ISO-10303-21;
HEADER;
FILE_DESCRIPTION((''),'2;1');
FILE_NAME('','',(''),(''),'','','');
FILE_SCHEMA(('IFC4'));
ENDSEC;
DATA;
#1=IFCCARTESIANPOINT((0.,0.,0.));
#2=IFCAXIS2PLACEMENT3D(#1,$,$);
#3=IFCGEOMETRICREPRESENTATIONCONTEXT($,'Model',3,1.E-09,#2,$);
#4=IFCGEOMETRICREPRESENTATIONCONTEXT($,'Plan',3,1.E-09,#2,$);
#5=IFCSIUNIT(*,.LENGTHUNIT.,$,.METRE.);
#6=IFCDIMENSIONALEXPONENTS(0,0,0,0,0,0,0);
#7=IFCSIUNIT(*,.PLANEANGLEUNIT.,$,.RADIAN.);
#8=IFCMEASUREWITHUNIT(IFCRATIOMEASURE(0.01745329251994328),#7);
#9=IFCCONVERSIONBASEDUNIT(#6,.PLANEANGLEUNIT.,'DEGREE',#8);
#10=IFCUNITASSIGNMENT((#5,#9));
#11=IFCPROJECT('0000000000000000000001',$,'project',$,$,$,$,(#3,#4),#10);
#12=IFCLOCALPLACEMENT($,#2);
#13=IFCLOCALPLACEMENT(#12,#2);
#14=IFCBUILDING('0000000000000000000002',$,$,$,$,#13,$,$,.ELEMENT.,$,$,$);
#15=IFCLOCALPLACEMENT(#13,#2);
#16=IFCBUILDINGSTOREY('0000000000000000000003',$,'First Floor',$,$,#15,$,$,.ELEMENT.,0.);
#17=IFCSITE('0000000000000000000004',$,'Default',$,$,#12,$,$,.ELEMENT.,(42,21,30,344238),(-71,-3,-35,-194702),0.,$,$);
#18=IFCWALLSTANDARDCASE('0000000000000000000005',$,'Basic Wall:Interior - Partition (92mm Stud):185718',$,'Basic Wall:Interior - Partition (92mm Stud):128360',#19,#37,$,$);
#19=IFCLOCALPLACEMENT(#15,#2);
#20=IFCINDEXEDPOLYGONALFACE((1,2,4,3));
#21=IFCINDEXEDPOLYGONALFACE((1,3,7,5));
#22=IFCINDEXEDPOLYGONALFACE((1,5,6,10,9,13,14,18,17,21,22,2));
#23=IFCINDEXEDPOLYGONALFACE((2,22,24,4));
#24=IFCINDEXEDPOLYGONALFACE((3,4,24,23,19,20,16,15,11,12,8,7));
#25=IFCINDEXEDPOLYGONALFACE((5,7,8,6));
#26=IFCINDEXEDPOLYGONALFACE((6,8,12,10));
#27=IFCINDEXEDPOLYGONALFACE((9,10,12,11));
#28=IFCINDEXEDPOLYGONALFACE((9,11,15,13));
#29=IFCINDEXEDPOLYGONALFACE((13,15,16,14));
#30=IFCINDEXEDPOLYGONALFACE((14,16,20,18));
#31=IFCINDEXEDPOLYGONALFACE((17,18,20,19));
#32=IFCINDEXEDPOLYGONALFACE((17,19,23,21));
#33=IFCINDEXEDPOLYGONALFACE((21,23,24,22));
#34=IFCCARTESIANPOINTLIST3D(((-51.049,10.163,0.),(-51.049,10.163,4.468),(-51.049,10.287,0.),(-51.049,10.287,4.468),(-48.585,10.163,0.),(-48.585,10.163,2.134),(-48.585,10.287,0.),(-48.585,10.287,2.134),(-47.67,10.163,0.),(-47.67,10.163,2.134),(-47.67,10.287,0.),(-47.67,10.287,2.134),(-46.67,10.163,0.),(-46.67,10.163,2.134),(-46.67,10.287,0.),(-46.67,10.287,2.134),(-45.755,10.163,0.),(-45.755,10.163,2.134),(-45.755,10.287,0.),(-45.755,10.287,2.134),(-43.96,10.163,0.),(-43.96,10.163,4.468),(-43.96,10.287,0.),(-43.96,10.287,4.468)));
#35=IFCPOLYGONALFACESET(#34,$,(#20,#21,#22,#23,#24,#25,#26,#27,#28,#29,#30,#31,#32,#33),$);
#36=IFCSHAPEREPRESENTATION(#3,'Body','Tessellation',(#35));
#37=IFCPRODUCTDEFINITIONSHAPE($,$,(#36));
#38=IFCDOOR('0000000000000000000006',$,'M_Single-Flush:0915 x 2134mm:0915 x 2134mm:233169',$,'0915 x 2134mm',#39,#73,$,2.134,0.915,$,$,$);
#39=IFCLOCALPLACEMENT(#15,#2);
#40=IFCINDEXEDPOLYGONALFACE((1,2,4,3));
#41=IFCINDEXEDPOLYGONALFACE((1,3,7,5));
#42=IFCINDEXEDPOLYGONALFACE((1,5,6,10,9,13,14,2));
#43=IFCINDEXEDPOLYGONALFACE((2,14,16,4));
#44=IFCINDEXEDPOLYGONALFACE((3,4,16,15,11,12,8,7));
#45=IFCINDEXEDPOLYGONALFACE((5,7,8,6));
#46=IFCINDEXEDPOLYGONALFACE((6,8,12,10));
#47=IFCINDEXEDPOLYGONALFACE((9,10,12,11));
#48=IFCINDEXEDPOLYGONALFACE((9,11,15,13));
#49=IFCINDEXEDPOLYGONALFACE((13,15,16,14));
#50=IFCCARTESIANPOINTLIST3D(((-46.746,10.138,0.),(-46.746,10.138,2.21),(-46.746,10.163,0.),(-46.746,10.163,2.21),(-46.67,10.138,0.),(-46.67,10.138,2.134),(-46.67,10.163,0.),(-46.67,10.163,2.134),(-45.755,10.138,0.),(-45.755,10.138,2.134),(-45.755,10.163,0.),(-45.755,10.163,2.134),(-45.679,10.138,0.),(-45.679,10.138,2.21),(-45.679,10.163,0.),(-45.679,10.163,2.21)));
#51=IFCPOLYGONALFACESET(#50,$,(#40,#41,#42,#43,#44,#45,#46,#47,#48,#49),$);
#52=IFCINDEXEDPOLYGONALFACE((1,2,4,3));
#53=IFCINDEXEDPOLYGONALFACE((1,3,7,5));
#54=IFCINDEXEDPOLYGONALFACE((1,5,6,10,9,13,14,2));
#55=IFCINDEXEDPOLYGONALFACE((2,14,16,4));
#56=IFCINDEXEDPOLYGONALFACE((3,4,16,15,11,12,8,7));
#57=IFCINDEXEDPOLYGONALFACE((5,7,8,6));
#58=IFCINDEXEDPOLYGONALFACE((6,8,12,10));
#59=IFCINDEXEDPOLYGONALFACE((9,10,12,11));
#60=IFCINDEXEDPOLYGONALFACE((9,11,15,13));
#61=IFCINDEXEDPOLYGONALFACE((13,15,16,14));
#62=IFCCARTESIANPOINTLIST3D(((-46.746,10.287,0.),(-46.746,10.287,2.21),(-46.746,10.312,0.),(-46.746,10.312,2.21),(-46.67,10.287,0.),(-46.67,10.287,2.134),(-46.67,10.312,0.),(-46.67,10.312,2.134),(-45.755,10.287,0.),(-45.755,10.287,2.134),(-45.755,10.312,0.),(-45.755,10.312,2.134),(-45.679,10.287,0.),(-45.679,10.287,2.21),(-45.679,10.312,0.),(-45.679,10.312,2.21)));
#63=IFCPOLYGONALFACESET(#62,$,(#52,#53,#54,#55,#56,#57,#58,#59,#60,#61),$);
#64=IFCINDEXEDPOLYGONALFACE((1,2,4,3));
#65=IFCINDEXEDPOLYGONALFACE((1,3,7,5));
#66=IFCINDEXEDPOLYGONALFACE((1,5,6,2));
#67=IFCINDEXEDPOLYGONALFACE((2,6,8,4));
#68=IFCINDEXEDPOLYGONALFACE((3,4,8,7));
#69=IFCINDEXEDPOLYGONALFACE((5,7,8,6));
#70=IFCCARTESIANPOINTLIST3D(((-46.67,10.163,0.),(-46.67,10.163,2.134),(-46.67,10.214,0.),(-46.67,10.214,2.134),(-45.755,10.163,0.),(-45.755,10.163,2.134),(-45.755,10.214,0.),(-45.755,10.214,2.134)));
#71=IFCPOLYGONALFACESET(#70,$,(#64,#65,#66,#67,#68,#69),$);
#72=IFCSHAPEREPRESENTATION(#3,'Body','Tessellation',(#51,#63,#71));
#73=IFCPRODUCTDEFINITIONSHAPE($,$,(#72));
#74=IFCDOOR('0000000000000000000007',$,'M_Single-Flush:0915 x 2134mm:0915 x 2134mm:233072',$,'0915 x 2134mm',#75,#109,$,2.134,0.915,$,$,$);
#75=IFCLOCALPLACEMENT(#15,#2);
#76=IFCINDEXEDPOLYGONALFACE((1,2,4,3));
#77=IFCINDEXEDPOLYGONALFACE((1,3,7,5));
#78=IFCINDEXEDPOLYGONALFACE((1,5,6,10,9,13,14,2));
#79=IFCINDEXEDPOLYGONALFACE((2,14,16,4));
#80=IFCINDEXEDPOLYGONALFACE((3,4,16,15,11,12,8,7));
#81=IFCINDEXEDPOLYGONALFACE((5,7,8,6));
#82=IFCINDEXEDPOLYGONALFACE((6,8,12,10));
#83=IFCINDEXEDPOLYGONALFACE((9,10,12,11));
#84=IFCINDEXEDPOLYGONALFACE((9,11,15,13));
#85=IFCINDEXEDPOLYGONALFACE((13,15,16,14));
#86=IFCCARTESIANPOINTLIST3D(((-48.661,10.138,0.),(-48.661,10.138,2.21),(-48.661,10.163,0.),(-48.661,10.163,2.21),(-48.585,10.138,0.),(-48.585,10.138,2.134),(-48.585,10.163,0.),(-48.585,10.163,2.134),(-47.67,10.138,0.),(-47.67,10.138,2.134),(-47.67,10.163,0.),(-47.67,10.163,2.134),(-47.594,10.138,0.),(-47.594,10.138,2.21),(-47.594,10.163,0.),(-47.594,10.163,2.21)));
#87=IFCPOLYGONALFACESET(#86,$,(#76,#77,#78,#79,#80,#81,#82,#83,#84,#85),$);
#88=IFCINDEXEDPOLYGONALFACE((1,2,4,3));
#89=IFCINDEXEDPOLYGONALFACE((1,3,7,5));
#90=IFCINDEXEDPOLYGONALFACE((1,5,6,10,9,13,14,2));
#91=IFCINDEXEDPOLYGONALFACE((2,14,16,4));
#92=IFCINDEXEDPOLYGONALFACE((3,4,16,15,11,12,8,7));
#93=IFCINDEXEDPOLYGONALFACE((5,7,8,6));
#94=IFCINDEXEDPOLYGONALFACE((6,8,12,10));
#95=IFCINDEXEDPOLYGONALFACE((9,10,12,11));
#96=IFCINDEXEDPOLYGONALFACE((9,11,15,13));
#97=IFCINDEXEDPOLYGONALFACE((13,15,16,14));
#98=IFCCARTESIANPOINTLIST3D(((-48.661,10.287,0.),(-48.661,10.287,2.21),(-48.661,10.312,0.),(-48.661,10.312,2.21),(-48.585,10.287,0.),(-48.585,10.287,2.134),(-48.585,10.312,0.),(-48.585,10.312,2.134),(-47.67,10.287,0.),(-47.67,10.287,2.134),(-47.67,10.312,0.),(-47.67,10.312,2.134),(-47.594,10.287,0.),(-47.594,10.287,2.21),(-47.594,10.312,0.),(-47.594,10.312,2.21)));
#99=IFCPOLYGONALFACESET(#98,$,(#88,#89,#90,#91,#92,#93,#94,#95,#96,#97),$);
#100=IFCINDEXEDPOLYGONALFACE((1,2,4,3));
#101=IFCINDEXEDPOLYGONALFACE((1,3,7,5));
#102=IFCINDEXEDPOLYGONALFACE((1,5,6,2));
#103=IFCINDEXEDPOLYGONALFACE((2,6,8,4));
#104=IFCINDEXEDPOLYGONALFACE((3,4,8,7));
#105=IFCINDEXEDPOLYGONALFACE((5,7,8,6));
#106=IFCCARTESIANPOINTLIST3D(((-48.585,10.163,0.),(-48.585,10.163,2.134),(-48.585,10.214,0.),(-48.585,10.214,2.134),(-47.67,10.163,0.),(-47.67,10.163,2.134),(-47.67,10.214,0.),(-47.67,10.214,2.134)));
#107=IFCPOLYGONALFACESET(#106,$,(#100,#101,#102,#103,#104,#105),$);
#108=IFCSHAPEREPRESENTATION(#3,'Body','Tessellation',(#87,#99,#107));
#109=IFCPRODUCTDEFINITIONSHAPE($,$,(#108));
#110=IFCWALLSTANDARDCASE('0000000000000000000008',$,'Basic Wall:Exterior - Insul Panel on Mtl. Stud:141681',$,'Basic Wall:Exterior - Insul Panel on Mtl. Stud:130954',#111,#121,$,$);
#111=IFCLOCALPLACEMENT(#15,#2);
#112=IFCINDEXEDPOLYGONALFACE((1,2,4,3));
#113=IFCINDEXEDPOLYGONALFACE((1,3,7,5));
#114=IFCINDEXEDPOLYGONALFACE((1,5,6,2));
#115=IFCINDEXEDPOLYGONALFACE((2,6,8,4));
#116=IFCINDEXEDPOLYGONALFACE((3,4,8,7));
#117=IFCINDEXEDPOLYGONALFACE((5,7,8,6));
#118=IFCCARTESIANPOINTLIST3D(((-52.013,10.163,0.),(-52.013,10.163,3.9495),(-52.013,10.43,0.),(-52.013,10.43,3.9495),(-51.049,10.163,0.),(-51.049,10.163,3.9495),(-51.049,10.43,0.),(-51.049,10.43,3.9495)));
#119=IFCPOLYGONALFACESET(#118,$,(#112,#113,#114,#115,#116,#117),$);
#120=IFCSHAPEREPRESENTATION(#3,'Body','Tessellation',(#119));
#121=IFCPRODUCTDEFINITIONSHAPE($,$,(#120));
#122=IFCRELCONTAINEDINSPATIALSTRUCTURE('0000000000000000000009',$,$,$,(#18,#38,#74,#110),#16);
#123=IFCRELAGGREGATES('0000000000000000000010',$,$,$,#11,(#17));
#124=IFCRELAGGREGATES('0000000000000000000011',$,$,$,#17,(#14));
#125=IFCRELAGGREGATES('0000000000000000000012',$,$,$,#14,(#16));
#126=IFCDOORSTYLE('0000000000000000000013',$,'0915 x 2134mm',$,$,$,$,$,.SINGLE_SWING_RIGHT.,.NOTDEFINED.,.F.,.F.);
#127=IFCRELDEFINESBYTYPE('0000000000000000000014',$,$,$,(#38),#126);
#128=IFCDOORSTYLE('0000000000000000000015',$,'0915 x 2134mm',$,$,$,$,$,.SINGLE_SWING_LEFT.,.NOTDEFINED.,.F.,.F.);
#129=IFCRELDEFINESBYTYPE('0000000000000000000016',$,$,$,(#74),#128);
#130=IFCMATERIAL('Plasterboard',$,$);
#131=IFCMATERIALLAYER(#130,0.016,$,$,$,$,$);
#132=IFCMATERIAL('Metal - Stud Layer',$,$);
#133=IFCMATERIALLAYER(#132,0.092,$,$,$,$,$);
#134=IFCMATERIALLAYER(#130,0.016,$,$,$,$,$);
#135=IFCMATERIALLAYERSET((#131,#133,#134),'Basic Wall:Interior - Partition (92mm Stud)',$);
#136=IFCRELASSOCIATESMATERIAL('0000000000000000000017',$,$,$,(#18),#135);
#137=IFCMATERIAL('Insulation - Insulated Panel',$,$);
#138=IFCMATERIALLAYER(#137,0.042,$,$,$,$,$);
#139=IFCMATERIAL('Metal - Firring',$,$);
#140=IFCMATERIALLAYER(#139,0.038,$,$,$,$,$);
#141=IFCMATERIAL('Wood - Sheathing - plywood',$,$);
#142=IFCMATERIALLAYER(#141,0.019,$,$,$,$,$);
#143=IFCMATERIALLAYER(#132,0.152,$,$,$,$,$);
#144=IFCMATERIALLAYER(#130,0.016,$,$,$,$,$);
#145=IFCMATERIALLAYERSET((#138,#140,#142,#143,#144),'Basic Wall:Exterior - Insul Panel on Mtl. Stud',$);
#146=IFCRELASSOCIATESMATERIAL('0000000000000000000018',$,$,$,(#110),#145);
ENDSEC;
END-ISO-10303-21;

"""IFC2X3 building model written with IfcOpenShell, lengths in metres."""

from ifc_helpers import new_model, entity, si_unit, converted_unit, frame, frame_2d, origin, origin_2d_with_axis, place, context, project, spatial, polyline, rectangle, outline, extrude, source, transform, mapped, material, layer, layer_set, layer_usage, type_object, type_shapes, element, fill, save


model = new_model("IFC2X3")

# Units and contexts
model_context = context("Model", 3, precision=1e-09, world=origin())
plan_context = context("Plan", 3, precision=1e-09, world=origin())
ifc_project = project(units=[si_unit("LENGTHUNIT", "METRE"), converted_unit("PLANEANGLEUNIT", "DEGREE", entity("IfcRatioMeasure", 0.01745329251994328), si_unit("PLANEANGLEUNIT", "RADIAN"), dimensions=[0, 0, 0, 0, 0, 0, 0])], contexts=[model_context, plan_context])

# Site, building, storey
site_placement = place(None, origin())
site = spatial("IfcSite", under=ifc_project, at=site_placement, Name="Default", CompositionType="ELEMENT", RefLatitude=(42, 21, 30, 344238), RefLongitude=(-71, -3, -35, -194702), RefElevation=0.0)
building_placement = place(site_placement, origin())
building = spatial("IfcBuilding", under=site, at=building_placement, CompositionType="ELEMENT")
storey_placement = place(building_placement, origin())
storey = spatial("IfcBuildingStorey", under=building, at=storey_placement, Name="First Floor", CompositionType="ELEMENT", Elevation=0.0)

# Shared definitions
ifc_material_1 = material(Name="Insulation - Insulated Panel")
ifc_layer_1 = layer(ifc_material_1, 0.042)
ifc_material_2 = material(Name="Metal - Firring")
ifc_layer_2 = layer(ifc_material_2, 0.038)
ifc_material_3 = material(Name="Wood - Sheathing - plywood")
ifc_layer_3 = layer(ifc_material_3, 0.019)
ifc_material_4 = material(Name="Metal - Stud Layer")
ifc_layer_4 = layer(ifc_material_4, 0.152)
ifc_material_5 = material(Name="Plasterboard")
ifc_layer_5 = layer(ifc_material_5, 0.016)
ifc_layer_set_1 = layer_set([ifc_layer_1, ifc_layer_2, ifc_layer_3, ifc_layer_4, ifc_layer_5], Name="Basic Wall:Exterior - Insul Panel on Mtl. Stud")
ifc_layer_usage_1 = layer_usage(ifc_layer_set_1, "AXIS2", "NEGATIVE", 0.1335)

# Wall, openings, doors
ifc_layer_6 = layer(ifc_material_5, 0.016)
ifc_layer_7 = layer(ifc_material_4, 0.092)
ifc_layer_8 = layer(ifc_material_5, 0.016)
ifc_layer_set_2 = layer_set([ifc_layer_6, ifc_layer_7, ifc_layer_8], Name="Basic Wall:Interior - Partition (92mm Stud)")
ifc_layer_usage_2 = layer_usage(ifc_layer_set_2, "AXIS2", "NEGATIVE", 0.062)
wall_1_placement = place(storey_placement, frame((-51.049, 10.225, 0.0)))
wall_1 = element("IfcWallStandardCase", 1, at=wall_1_placement, inside=storey, material=ifc_layer_usage_2, Name="Basic Wall:Interior - Partition (92mm Stud):185718", ObjectType="Basic Wall:Interior - Partition (92mm Stud):128360", context=model_context, shape_type="SweptSolid", body=[
    extrude(rectangle(XDim=7.089, YDim=0.124, at=frame_2d((3.5445, 0.0), x_axis=(-1.0, 0.0))), origin(), (0.0, 0.0, 1.0), 4.468),
])
opening_1_placement = place(wall_1_placement, frame((3.379, 0.062, 0.0)))
opening_1 = element("IfcOpeningElement", 2, at=opening_1_placement, cuts=wall_1, ObjectType="Opening", context=model_context, shape_type="SweptSolid", body=[
    extrude(rectangle(XDim=0.915, YDim=2.134, at=frame_2d((1.067, 0.4575), x_axis=(0.0, -1.0))), frame((0.0, 0.0, 0.0), z_axis=(0.0, -1.0, 0.0), x_axis=(0.0, 0.0, 1.0)), (0.0, 0.0, 1.0), 0.124),
])
opening_2_placement = place(wall_1_placement, frame((5.294, 0.062, 0.0)))
opening_2 = element("IfcOpeningElement", 3, at=opening_2_placement, cuts=wall_1, ObjectType="Opening", context=model_context, shape_type="SweptSolid", body=[
    extrude(rectangle(XDim=0.915, YDim=2.134, at=frame_2d((1.067, 0.4575), x_axis=(0.0, 1.0))), frame((0.0, 0.0, 0.0), z_axis=(0.0, -1.0, 0.0), x_axis=(0.0, 0.0, 1.0)), (0.0, 0.0, 1.0), 0.124),
])
door_style_1 = type_object("IfcDoorStyle", Name="0915 x 2134mm", ConstructionType="NOTDEFINED", OperationType="SINGLE_SWING_RIGHT", ParameterTakesPrecedence=False, Sizeable=False)
shared_shape_1 = source(origin(), model_context, "Body", "SweptSolid", [
    extrude(outline(polyline([(-0.5335, -1.124), (0.5335, -1.124), (0.5335, 1.086), (0.4575, 1.086), (0.4575, -1.048), (-0.4575, -1.048), (-0.4575, 1.086), (-0.5335, 1.086), (-0.5335, -1.124)])), frame((0.4575, 0.124, 1.086), z_axis=(0.0, 1.0, 0.0), x_axis=(1.0, 0.0, 0.0)), (0.0, 0.0, 1.0), 0.025),
    extrude(outline(polyline([(-1.124, -0.5335), (1.086, -0.5335), (1.086, -0.4575), (-1.048, -0.4575), (-1.048, 0.4575), (1.086, 0.4575), (1.086, 0.5335), (-1.124, 0.5335), (-1.124, -0.5335)])), frame((0.4575, -0.025, 1.086), z_axis=(0.0, 1.0, 0.0), x_axis=(0.0, 0.0, -1.0)), (0.0, 0.0, 1.0), 0.025),
    extrude(rectangle(XDim=0.051, YDim=0.915, at=origin_2d_with_axis()), frame((0.4575, 0.0985, 0.0), z_axis=(0.0, 0.0, 1.0), x_axis=(0.0, 1.0, 0.0)), (0.0, 0.0, 1.0), 2.134),
])
type_shapes(door_style_1, [shared_shape_1])
door_1_placement = place(opening_2_placement, frame((0.0, 0.0, 0.0), z_axis=(0.0, 0.0, 1.0), x_axis=(-1.0, 0.0, 0.0)))
door_1 = element("IfcDoor", 4, at=door_1_placement, inside=storey, type_object=door_style_1, Name="M_Single-Flush:0915 x 2134mm:0915 x 2134mm:233169", ObjectType="0915 x 2134mm", OverallHeight=2.134, OverallWidth=0.915, context=model_context, shape_type="MappedRepresentation", body=[
    mapped(shared_shape_1, transform((0.0, 0.0, 0.0), scale=1.0)),
])
fill(opening_2, door_1)
door_style_2 = type_object("IfcDoorStyle", Name="0915 x 2134mm", ConstructionType="NOTDEFINED", OperationType="SINGLE_SWING_LEFT", ParameterTakesPrecedence=False, Sizeable=False)
shared_shape_2 = source(origin(), model_context, "Body", "SweptSolid", [
    extrude(outline(polyline([(-0.5335, -1.124), (0.5335, -1.124), (0.5335, 1.086), (0.4575, 1.086), (0.4575, -1.048), (-0.4575, -1.048), (-0.4575, 1.086), (-0.5335, 1.086), (-0.5335, -1.124)])), frame((0.4575, 0.149, 1.086), z_axis=(0.0, -1.0, 0.0), x_axis=(-1.0, 0.0, 0.0)), (0.0, 0.0, 1.0), 0.025),
    extrude(outline(polyline([(-1.124, -0.5335), (1.086, -0.5335), (1.086, -0.4575), (-1.048, -0.4575), (-1.048, 0.4575), (1.086, 0.4575), (1.086, 0.5335), (-1.124, 0.5335), (-1.124, -0.5335)])), frame((0.4575, 0.0, 1.086), z_axis=(0.0, -1.0, 0.0), x_axis=(0.0, 0.0, -1.0)), (0.0, 0.0, 1.0), 0.025),
    extrude(rectangle(XDim=0.915, YDim=0.051, at=origin_2d_with_axis()), frame((0.4575, 0.0985, 0.0)), (0.0, 0.0, 1.0), 2.134),
])
type_shapes(door_style_2, [shared_shape_2])
door_2_placement = place(opening_1_placement, frame((0.0, 0.0, 0.0), z_axis=(0.0, 0.0, 1.0), x_axis=(-1.0, 0.0, 0.0)))
door_2 = element("IfcDoor", 5, at=door_2_placement, inside=storey, type_object=door_style_2, Name="M_Single-Flush:0915 x 2134mm:0915 x 2134mm:233072", ObjectType="0915 x 2134mm", OverallHeight=2.134, OverallWidth=0.915, context=model_context, shape_type="MappedRepresentation", body=[
    mapped(shared_shape_2, transform((0.0, 0.0, 0.0), scale=1.0)),
])
fill(opening_1, door_2)

# Wall
wall_2_placement = place(storey_placement, frame((-52.013, 10.2965, 0.0)))
element("IfcWallStandardCase", 6, at=wall_2_placement, inside=storey, material=ifc_layer_usage_1, Name="Basic Wall:Exterior - Insul Panel on Mtl. Stud:141681", ObjectType="Basic Wall:Exterior - Insul Panel on Mtl. Stud:130954", context=model_context, shape_type="SweptSolid", body=[
    extrude(rectangle(XDim=0.964, YDim=0.267, at=frame_2d((0.482, 0.0), x_axis=(-1.0, 0.0))), origin(), (0.0, 0.0, 1.0), 3.9495),
])

save(model, "model.ifc")
